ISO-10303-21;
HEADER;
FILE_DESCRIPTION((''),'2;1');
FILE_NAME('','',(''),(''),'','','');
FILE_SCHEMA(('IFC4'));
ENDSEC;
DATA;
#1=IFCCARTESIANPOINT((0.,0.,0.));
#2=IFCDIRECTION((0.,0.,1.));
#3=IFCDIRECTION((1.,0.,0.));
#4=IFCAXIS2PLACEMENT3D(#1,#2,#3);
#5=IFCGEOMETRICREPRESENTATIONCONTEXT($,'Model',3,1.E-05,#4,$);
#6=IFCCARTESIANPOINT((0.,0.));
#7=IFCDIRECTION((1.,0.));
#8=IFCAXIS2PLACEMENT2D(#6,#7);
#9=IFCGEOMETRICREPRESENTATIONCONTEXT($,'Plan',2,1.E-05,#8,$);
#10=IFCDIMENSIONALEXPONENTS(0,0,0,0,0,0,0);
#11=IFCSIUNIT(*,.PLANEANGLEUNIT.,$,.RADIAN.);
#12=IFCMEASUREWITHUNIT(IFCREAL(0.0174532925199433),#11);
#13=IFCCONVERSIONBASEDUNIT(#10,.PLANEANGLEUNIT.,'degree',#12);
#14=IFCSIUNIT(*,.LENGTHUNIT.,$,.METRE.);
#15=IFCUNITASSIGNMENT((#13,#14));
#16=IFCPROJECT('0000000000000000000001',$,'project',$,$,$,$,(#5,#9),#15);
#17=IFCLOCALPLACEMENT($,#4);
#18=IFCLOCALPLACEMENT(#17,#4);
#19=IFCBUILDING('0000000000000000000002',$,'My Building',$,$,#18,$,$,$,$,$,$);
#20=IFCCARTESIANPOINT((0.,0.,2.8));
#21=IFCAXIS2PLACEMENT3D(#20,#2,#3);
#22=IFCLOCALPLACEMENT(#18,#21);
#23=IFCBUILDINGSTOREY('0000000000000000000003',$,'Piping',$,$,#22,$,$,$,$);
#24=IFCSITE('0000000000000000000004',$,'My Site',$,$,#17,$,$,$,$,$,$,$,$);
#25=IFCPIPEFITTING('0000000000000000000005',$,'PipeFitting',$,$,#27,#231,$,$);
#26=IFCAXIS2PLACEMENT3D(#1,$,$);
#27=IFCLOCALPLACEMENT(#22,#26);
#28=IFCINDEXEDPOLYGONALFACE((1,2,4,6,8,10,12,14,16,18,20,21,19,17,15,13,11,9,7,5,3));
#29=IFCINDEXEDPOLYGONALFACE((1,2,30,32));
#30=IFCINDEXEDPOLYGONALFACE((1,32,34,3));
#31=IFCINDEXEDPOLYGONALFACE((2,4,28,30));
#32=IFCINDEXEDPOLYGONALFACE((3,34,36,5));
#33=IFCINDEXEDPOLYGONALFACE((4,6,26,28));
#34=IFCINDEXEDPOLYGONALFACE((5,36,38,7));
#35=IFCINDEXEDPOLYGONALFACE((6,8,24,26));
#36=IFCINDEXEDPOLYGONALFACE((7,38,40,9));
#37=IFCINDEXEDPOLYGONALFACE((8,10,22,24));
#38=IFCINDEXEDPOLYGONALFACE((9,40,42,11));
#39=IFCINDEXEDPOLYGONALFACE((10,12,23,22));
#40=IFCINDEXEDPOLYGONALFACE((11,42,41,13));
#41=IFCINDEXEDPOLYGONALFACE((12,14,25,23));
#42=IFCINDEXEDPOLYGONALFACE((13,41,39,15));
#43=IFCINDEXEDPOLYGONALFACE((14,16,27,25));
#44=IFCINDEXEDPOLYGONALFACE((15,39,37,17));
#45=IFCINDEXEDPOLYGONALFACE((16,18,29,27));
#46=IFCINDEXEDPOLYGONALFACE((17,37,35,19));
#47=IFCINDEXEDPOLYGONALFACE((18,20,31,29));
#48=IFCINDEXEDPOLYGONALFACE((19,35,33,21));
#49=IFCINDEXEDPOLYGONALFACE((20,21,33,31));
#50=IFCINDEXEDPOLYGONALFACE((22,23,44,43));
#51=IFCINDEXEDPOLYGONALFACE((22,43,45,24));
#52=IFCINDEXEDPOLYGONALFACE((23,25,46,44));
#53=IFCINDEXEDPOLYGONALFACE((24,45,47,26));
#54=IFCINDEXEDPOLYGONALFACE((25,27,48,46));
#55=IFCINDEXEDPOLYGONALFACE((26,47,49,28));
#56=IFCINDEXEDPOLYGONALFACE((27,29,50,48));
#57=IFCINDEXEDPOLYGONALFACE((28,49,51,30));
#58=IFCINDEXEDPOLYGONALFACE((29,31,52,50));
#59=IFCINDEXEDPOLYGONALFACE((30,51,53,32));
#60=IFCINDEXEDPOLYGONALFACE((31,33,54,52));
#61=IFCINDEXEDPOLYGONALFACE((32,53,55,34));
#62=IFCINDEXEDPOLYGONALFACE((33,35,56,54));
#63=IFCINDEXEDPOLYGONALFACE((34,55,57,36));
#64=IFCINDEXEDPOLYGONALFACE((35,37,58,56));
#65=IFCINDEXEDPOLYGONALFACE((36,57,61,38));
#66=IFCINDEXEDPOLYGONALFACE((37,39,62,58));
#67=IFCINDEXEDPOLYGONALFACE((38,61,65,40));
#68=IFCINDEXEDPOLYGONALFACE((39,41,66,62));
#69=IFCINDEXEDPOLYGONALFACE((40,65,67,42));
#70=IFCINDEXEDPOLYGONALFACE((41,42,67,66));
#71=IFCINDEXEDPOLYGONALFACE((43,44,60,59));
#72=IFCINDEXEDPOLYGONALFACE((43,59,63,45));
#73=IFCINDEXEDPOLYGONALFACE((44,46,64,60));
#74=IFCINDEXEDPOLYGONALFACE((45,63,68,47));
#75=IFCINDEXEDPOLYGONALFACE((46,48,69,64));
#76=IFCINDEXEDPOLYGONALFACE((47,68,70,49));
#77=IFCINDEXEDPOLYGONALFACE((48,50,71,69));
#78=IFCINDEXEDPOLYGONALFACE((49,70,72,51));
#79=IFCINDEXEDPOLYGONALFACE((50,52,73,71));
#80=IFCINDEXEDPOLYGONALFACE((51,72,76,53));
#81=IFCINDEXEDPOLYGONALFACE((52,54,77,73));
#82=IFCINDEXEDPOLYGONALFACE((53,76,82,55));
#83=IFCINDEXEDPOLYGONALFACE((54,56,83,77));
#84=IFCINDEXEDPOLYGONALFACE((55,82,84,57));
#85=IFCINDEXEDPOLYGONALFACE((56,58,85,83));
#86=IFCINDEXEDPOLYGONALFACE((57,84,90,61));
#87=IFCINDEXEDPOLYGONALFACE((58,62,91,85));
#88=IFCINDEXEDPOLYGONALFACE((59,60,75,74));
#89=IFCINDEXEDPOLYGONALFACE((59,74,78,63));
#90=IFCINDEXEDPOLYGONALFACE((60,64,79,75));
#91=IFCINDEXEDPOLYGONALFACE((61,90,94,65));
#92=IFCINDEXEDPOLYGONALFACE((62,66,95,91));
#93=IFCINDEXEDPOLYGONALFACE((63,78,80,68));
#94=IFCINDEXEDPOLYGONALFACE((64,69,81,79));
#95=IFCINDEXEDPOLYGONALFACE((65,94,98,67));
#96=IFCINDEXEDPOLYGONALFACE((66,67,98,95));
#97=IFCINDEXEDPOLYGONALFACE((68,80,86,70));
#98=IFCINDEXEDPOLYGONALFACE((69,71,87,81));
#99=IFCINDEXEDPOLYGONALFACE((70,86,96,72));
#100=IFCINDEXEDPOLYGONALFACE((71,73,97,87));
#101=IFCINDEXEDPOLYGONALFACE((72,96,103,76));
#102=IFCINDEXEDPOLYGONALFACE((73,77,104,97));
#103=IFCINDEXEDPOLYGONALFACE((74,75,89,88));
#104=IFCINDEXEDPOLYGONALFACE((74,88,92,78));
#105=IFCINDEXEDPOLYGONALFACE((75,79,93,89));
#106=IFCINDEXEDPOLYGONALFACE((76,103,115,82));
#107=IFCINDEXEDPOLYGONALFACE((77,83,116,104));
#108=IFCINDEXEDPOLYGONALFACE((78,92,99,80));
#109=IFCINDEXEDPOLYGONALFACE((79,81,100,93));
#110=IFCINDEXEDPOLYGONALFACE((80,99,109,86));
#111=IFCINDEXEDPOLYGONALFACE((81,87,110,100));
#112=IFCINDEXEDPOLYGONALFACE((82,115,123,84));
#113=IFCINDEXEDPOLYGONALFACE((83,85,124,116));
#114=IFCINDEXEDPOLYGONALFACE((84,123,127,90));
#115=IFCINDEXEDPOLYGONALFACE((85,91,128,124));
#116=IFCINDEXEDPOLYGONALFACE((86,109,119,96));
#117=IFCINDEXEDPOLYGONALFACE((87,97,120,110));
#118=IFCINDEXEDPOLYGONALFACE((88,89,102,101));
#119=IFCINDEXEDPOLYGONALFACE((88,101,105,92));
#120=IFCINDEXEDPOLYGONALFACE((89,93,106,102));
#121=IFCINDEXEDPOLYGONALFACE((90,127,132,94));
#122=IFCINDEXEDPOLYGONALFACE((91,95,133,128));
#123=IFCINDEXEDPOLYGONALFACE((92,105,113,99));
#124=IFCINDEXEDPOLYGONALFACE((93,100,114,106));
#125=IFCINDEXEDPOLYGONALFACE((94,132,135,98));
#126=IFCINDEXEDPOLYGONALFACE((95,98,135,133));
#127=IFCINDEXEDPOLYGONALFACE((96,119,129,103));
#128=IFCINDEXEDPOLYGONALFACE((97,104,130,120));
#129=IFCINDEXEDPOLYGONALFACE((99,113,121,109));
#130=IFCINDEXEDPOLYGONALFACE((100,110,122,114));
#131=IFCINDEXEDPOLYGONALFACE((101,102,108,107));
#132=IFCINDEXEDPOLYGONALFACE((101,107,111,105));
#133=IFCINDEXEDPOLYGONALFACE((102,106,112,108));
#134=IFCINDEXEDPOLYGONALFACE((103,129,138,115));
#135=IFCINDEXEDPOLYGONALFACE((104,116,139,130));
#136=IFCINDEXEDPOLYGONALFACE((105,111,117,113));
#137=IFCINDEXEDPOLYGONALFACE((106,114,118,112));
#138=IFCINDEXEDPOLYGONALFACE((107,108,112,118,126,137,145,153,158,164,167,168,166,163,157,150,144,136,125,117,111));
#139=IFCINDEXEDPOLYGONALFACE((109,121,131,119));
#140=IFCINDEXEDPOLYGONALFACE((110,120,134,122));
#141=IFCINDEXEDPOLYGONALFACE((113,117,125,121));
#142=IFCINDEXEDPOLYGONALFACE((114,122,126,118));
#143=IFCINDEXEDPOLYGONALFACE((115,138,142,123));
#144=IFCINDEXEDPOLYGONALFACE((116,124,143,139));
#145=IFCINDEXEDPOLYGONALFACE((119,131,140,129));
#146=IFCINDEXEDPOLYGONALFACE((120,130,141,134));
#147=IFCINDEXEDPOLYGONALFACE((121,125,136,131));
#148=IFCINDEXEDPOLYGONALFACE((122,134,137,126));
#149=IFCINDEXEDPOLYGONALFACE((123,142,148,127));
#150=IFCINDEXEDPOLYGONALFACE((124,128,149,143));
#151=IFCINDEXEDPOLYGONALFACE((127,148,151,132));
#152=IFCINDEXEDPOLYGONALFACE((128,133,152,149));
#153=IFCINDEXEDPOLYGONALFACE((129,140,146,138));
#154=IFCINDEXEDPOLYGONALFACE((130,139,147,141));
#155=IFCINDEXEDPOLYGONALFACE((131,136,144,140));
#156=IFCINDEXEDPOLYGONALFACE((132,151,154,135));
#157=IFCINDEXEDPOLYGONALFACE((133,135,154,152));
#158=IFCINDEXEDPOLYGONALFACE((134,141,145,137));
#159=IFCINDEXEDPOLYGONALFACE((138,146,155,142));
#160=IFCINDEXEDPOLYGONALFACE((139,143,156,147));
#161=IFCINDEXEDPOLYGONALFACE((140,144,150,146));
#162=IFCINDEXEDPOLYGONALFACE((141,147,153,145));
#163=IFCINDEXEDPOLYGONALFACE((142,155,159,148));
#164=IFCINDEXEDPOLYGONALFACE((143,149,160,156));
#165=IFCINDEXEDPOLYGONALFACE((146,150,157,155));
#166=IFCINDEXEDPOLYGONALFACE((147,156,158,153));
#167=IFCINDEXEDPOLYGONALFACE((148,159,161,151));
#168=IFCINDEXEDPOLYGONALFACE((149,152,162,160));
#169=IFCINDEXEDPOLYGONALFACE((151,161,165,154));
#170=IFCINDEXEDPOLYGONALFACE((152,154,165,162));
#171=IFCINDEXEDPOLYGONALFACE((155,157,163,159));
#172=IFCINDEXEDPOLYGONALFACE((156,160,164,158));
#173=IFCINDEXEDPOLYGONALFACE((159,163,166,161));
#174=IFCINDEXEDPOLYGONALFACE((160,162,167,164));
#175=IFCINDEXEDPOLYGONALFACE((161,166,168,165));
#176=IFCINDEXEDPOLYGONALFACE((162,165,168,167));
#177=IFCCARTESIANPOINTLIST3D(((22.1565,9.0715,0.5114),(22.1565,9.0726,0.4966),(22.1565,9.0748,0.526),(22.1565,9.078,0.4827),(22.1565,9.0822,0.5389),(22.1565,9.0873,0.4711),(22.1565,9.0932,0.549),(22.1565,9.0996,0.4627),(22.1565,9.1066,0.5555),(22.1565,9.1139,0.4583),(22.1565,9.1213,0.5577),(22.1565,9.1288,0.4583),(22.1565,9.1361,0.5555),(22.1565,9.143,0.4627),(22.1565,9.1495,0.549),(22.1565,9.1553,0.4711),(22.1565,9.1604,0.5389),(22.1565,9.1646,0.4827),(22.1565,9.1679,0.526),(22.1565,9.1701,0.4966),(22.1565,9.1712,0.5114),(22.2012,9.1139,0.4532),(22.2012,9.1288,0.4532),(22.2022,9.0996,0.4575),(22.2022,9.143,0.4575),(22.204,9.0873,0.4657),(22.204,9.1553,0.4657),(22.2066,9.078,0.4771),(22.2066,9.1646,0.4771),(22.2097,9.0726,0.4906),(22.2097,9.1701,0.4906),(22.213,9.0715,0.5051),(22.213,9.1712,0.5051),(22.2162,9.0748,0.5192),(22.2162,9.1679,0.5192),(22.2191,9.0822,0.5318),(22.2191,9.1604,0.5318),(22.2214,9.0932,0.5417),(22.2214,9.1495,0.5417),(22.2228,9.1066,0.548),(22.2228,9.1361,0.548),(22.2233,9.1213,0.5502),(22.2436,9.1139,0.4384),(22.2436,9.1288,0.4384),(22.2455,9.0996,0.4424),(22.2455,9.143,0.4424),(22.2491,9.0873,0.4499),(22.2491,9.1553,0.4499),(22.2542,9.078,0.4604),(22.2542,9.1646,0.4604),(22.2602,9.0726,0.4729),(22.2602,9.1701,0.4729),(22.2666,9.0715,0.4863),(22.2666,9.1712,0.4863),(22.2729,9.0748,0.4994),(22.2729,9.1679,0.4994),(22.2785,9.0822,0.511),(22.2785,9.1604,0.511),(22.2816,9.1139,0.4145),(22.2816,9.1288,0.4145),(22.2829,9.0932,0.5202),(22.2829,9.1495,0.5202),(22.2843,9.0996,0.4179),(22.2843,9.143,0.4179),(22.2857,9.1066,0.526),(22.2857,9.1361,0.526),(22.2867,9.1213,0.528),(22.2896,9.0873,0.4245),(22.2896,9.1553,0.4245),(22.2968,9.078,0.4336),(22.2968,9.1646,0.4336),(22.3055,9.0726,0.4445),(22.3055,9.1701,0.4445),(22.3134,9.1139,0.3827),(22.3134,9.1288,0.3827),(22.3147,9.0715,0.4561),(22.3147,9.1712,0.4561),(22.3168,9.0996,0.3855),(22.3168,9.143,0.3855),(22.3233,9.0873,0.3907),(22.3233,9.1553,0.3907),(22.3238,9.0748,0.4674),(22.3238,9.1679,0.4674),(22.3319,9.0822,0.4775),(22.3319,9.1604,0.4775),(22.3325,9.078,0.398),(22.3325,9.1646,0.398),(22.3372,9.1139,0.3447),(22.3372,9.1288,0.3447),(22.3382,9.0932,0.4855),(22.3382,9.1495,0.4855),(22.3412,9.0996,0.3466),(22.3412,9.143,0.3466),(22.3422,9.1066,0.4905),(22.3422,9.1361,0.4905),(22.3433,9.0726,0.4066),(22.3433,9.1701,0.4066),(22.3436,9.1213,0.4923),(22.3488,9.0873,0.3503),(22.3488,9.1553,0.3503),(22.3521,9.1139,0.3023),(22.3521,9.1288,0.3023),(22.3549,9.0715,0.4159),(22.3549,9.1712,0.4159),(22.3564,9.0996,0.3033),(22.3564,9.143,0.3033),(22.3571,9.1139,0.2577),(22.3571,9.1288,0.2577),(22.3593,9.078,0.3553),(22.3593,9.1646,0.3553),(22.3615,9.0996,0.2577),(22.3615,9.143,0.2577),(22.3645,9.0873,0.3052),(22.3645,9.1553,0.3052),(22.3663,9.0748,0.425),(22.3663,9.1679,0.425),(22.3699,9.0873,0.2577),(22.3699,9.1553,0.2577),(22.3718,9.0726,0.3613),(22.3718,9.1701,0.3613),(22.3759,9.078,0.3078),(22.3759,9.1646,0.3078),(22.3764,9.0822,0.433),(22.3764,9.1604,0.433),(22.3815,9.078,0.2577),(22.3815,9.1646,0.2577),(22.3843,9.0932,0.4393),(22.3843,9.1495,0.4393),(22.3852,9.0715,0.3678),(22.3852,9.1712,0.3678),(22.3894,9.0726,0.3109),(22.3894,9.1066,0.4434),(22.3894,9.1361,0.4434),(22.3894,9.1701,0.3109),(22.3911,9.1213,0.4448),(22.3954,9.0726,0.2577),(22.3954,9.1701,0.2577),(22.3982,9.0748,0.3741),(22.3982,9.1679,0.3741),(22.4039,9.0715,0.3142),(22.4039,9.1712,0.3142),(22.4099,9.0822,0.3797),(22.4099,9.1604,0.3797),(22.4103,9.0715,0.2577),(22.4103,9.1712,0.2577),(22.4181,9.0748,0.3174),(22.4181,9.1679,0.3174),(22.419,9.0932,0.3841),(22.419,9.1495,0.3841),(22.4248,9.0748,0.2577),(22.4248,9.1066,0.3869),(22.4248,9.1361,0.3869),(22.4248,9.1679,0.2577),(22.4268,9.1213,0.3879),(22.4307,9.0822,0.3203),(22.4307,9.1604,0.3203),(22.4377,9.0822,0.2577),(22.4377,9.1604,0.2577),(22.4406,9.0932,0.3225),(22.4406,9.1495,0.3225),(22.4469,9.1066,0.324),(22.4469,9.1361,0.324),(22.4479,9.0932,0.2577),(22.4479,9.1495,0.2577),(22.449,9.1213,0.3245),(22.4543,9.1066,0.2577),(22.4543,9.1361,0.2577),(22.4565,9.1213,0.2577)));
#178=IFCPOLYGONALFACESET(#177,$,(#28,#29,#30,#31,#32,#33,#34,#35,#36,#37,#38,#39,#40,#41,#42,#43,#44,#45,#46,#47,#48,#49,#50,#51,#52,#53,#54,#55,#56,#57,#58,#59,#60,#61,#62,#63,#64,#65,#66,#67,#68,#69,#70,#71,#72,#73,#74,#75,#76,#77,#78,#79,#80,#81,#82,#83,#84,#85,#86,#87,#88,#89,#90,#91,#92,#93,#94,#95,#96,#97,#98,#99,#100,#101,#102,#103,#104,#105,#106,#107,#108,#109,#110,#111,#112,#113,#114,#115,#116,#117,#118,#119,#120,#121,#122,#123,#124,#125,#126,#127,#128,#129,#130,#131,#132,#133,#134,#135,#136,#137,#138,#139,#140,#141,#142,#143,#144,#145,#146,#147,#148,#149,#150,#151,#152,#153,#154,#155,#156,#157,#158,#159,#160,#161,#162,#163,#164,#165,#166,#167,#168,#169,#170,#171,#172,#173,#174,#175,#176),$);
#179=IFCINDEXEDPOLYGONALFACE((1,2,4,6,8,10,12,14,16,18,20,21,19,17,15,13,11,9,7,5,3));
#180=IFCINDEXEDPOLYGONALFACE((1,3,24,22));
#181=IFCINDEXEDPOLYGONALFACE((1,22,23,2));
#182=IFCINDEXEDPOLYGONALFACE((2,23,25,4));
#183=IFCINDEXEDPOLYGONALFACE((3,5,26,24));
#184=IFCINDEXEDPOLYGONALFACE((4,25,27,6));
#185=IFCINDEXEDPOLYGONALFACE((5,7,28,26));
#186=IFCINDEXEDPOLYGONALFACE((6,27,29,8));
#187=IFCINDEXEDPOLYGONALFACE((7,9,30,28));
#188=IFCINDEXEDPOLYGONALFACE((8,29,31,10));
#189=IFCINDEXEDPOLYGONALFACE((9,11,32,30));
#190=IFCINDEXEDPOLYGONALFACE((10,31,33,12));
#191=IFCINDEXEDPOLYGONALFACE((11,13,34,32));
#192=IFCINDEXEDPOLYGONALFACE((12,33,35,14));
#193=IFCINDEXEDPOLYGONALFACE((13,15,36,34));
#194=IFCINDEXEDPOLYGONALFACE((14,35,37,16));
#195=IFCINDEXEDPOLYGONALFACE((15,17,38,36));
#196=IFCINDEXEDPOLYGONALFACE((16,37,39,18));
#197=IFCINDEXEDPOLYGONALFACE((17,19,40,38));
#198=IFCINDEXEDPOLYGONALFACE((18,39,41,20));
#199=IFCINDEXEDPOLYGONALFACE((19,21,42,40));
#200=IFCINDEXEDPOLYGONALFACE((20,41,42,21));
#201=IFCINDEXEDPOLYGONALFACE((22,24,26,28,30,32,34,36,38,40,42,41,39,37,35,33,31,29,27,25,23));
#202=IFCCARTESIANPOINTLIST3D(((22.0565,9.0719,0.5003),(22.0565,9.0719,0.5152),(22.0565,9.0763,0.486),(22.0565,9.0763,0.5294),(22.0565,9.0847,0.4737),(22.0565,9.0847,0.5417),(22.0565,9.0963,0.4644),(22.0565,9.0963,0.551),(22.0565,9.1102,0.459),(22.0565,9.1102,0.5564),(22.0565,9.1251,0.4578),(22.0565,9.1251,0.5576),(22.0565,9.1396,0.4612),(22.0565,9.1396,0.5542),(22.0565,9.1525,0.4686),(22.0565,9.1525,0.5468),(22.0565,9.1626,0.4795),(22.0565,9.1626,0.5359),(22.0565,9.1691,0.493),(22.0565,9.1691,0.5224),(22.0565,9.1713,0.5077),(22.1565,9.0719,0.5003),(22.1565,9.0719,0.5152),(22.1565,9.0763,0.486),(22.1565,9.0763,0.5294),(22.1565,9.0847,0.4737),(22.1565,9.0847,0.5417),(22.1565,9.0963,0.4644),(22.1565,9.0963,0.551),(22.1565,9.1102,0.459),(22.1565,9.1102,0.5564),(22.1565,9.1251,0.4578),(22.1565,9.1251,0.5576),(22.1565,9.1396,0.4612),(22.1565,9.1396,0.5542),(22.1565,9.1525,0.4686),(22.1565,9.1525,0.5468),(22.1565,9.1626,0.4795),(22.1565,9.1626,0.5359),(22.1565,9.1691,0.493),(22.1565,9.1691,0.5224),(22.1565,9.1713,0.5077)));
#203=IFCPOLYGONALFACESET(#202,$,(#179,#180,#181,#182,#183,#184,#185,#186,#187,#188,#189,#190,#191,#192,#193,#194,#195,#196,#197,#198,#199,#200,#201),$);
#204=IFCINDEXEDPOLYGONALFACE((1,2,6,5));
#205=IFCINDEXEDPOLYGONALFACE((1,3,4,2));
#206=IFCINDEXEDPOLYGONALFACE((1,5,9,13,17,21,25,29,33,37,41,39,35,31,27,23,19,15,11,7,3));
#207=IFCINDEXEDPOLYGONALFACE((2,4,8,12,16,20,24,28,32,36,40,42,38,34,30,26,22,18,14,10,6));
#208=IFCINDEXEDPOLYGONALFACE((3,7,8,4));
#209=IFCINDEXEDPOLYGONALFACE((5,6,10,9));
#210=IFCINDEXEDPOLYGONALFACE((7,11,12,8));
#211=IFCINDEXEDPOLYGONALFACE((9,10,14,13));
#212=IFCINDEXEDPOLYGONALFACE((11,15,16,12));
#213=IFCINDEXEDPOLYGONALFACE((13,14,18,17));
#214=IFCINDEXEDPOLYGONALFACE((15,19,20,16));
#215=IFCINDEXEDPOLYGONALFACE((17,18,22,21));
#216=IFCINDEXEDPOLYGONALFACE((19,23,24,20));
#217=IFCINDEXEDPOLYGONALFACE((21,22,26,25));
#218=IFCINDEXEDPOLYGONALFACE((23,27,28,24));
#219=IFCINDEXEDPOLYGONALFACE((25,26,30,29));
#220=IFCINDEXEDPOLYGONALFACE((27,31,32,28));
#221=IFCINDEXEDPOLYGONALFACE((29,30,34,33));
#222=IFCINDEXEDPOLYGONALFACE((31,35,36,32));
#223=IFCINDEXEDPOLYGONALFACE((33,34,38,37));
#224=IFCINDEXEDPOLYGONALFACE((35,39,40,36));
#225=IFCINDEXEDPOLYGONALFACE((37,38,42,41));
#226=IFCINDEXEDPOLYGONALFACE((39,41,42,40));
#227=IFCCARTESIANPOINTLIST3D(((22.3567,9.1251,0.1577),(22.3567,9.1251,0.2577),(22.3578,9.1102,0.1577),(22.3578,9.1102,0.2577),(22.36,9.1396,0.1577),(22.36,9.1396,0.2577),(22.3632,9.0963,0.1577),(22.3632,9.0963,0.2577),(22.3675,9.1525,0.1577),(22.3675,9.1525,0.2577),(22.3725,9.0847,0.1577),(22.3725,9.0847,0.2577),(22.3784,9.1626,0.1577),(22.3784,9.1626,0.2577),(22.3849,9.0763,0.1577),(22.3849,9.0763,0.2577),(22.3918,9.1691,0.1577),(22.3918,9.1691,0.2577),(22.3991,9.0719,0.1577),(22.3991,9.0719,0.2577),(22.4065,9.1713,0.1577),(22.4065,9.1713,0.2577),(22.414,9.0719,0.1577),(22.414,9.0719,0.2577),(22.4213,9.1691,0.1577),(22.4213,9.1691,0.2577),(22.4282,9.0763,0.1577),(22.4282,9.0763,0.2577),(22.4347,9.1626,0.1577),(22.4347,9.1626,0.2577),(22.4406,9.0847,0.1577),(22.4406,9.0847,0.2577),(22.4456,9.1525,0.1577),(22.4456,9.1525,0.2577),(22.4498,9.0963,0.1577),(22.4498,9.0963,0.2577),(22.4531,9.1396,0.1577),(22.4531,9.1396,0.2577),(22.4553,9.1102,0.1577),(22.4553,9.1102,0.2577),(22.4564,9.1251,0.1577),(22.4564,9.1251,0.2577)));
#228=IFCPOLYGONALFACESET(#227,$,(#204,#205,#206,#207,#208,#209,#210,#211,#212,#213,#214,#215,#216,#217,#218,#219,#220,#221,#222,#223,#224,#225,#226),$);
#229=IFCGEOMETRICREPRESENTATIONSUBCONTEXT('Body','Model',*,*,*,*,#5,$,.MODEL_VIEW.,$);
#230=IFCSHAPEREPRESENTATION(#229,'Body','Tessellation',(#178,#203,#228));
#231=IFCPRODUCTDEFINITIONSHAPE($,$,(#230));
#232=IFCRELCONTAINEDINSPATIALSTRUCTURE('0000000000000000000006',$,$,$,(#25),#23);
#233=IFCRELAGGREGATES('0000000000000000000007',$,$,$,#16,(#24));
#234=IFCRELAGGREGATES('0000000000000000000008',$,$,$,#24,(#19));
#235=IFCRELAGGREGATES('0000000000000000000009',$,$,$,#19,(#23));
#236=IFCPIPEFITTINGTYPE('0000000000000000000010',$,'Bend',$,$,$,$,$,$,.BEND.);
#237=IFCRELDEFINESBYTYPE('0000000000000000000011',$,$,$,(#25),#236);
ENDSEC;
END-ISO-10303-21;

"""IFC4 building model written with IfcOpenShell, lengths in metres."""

from ifc_helpers import new_model, entity, si_unit, converted_unit, frame, origin_with_axes, origin_2d_with_axis, place, context, subcontext, project, spatial, circle, extrude, source, transform, mapped, type_object, type_shapes, element, save


model = new_model("IFC4")

# Units and contexts
model_context = context("Model", 3, precision=1e-05, world=origin_with_axes())
plan_context = context("Plan", 2, precision=1e-05, world=origin_2d_with_axis())
body_context = subcontext(model_context, "Body", "Model", "MODEL_VIEW")
ifc_project = project(units=[converted_unit("PLANEANGLEUNIT", "degree", entity("IfcReal", 0.0174532925199433), si_unit("PLANEANGLEUNIT", "RADIAN"), dimensions=[0, 0, 0, 0, 0, 0, 0]), si_unit("LENGTHUNIT", "METRE")], contexts=[model_context, plan_context])

# Site, building, storey
site_placement = place(None, origin_with_axes())
site = spatial("IfcSite", under=ifc_project, at=site_placement, Name="My Site")
building_placement = place(site_placement, origin_with_axes())
building = spatial("IfcBuilding", under=site, at=building_placement, Name="My Building")
storey_placement = place(building_placement, frame((0.0, 0.0, 2.8), z_axis=(0.0, 0.0, 1.0), x_axis=(1.0, 0.0, 0.0)))
storey = spatial("IfcBuildingStorey", under=building, at=storey_placement, Name="Piping")

# Pipe fitting
pipe_fitting_type_1 = type_object("IfcPipeFittingType", Name="Bend", PredefinedType="BEND")
shared_shape_1 = source(origin_with_axes(), body_context, "Body", "SolidModel", [
    entity("IfcSweptDiskSolid", entity("IfcIndexedPolyCurve", entity("IfcCartesianPointList3D", [[0.0, 0.0, 0.1], [0.0, -0.0732, 0.2768], [0.0, -0.25, 0.35]]), [entity("IfcArcIndex", [1, 2, 3])]), 0.05),
    extrude(circle(Radius=0.05), origin_with_axes(), (0.0, 0.0, 1.0), 0.1),
    extrude(circle(Radius=0.05), frame((0.0, -0.25, 0.35), z_axis=(0.0, -1.0, 0.0), x_axis=(1.0, 0.0, 0.0)), (0.0, 0.0, 1.0), 0.1),
])
type_shapes(pipe_fitting_type_1, [shared_shape_1])
for number, where, z_axis, x_axis, name in (
    (1, (22.0565, 9.1213, 0.5077), (1.0, 0.0, 0.0), (0.0, 1.0, 0.0), "PipeFitting"),
):
    element("IfcPipeFitting", number, at=place(storey_placement, frame(where, z_axis=z_axis, x_axis=x_axis)), inside=storey, type_object=pipe_fitting_type_1, Name=name, context=body_context, shape_type="MappedRepresentation", body=[
        mapped(shared_shape_1, transform((0.0, 0.0, 0.0), x_axis=(1.0, 0.0, 0.0), y_axis=(0.0, 1.0, 0.0), z_axis=(0.0, 0.0, 1.0), scale=1.0)),
    ])

save(model, "model.ifc")
